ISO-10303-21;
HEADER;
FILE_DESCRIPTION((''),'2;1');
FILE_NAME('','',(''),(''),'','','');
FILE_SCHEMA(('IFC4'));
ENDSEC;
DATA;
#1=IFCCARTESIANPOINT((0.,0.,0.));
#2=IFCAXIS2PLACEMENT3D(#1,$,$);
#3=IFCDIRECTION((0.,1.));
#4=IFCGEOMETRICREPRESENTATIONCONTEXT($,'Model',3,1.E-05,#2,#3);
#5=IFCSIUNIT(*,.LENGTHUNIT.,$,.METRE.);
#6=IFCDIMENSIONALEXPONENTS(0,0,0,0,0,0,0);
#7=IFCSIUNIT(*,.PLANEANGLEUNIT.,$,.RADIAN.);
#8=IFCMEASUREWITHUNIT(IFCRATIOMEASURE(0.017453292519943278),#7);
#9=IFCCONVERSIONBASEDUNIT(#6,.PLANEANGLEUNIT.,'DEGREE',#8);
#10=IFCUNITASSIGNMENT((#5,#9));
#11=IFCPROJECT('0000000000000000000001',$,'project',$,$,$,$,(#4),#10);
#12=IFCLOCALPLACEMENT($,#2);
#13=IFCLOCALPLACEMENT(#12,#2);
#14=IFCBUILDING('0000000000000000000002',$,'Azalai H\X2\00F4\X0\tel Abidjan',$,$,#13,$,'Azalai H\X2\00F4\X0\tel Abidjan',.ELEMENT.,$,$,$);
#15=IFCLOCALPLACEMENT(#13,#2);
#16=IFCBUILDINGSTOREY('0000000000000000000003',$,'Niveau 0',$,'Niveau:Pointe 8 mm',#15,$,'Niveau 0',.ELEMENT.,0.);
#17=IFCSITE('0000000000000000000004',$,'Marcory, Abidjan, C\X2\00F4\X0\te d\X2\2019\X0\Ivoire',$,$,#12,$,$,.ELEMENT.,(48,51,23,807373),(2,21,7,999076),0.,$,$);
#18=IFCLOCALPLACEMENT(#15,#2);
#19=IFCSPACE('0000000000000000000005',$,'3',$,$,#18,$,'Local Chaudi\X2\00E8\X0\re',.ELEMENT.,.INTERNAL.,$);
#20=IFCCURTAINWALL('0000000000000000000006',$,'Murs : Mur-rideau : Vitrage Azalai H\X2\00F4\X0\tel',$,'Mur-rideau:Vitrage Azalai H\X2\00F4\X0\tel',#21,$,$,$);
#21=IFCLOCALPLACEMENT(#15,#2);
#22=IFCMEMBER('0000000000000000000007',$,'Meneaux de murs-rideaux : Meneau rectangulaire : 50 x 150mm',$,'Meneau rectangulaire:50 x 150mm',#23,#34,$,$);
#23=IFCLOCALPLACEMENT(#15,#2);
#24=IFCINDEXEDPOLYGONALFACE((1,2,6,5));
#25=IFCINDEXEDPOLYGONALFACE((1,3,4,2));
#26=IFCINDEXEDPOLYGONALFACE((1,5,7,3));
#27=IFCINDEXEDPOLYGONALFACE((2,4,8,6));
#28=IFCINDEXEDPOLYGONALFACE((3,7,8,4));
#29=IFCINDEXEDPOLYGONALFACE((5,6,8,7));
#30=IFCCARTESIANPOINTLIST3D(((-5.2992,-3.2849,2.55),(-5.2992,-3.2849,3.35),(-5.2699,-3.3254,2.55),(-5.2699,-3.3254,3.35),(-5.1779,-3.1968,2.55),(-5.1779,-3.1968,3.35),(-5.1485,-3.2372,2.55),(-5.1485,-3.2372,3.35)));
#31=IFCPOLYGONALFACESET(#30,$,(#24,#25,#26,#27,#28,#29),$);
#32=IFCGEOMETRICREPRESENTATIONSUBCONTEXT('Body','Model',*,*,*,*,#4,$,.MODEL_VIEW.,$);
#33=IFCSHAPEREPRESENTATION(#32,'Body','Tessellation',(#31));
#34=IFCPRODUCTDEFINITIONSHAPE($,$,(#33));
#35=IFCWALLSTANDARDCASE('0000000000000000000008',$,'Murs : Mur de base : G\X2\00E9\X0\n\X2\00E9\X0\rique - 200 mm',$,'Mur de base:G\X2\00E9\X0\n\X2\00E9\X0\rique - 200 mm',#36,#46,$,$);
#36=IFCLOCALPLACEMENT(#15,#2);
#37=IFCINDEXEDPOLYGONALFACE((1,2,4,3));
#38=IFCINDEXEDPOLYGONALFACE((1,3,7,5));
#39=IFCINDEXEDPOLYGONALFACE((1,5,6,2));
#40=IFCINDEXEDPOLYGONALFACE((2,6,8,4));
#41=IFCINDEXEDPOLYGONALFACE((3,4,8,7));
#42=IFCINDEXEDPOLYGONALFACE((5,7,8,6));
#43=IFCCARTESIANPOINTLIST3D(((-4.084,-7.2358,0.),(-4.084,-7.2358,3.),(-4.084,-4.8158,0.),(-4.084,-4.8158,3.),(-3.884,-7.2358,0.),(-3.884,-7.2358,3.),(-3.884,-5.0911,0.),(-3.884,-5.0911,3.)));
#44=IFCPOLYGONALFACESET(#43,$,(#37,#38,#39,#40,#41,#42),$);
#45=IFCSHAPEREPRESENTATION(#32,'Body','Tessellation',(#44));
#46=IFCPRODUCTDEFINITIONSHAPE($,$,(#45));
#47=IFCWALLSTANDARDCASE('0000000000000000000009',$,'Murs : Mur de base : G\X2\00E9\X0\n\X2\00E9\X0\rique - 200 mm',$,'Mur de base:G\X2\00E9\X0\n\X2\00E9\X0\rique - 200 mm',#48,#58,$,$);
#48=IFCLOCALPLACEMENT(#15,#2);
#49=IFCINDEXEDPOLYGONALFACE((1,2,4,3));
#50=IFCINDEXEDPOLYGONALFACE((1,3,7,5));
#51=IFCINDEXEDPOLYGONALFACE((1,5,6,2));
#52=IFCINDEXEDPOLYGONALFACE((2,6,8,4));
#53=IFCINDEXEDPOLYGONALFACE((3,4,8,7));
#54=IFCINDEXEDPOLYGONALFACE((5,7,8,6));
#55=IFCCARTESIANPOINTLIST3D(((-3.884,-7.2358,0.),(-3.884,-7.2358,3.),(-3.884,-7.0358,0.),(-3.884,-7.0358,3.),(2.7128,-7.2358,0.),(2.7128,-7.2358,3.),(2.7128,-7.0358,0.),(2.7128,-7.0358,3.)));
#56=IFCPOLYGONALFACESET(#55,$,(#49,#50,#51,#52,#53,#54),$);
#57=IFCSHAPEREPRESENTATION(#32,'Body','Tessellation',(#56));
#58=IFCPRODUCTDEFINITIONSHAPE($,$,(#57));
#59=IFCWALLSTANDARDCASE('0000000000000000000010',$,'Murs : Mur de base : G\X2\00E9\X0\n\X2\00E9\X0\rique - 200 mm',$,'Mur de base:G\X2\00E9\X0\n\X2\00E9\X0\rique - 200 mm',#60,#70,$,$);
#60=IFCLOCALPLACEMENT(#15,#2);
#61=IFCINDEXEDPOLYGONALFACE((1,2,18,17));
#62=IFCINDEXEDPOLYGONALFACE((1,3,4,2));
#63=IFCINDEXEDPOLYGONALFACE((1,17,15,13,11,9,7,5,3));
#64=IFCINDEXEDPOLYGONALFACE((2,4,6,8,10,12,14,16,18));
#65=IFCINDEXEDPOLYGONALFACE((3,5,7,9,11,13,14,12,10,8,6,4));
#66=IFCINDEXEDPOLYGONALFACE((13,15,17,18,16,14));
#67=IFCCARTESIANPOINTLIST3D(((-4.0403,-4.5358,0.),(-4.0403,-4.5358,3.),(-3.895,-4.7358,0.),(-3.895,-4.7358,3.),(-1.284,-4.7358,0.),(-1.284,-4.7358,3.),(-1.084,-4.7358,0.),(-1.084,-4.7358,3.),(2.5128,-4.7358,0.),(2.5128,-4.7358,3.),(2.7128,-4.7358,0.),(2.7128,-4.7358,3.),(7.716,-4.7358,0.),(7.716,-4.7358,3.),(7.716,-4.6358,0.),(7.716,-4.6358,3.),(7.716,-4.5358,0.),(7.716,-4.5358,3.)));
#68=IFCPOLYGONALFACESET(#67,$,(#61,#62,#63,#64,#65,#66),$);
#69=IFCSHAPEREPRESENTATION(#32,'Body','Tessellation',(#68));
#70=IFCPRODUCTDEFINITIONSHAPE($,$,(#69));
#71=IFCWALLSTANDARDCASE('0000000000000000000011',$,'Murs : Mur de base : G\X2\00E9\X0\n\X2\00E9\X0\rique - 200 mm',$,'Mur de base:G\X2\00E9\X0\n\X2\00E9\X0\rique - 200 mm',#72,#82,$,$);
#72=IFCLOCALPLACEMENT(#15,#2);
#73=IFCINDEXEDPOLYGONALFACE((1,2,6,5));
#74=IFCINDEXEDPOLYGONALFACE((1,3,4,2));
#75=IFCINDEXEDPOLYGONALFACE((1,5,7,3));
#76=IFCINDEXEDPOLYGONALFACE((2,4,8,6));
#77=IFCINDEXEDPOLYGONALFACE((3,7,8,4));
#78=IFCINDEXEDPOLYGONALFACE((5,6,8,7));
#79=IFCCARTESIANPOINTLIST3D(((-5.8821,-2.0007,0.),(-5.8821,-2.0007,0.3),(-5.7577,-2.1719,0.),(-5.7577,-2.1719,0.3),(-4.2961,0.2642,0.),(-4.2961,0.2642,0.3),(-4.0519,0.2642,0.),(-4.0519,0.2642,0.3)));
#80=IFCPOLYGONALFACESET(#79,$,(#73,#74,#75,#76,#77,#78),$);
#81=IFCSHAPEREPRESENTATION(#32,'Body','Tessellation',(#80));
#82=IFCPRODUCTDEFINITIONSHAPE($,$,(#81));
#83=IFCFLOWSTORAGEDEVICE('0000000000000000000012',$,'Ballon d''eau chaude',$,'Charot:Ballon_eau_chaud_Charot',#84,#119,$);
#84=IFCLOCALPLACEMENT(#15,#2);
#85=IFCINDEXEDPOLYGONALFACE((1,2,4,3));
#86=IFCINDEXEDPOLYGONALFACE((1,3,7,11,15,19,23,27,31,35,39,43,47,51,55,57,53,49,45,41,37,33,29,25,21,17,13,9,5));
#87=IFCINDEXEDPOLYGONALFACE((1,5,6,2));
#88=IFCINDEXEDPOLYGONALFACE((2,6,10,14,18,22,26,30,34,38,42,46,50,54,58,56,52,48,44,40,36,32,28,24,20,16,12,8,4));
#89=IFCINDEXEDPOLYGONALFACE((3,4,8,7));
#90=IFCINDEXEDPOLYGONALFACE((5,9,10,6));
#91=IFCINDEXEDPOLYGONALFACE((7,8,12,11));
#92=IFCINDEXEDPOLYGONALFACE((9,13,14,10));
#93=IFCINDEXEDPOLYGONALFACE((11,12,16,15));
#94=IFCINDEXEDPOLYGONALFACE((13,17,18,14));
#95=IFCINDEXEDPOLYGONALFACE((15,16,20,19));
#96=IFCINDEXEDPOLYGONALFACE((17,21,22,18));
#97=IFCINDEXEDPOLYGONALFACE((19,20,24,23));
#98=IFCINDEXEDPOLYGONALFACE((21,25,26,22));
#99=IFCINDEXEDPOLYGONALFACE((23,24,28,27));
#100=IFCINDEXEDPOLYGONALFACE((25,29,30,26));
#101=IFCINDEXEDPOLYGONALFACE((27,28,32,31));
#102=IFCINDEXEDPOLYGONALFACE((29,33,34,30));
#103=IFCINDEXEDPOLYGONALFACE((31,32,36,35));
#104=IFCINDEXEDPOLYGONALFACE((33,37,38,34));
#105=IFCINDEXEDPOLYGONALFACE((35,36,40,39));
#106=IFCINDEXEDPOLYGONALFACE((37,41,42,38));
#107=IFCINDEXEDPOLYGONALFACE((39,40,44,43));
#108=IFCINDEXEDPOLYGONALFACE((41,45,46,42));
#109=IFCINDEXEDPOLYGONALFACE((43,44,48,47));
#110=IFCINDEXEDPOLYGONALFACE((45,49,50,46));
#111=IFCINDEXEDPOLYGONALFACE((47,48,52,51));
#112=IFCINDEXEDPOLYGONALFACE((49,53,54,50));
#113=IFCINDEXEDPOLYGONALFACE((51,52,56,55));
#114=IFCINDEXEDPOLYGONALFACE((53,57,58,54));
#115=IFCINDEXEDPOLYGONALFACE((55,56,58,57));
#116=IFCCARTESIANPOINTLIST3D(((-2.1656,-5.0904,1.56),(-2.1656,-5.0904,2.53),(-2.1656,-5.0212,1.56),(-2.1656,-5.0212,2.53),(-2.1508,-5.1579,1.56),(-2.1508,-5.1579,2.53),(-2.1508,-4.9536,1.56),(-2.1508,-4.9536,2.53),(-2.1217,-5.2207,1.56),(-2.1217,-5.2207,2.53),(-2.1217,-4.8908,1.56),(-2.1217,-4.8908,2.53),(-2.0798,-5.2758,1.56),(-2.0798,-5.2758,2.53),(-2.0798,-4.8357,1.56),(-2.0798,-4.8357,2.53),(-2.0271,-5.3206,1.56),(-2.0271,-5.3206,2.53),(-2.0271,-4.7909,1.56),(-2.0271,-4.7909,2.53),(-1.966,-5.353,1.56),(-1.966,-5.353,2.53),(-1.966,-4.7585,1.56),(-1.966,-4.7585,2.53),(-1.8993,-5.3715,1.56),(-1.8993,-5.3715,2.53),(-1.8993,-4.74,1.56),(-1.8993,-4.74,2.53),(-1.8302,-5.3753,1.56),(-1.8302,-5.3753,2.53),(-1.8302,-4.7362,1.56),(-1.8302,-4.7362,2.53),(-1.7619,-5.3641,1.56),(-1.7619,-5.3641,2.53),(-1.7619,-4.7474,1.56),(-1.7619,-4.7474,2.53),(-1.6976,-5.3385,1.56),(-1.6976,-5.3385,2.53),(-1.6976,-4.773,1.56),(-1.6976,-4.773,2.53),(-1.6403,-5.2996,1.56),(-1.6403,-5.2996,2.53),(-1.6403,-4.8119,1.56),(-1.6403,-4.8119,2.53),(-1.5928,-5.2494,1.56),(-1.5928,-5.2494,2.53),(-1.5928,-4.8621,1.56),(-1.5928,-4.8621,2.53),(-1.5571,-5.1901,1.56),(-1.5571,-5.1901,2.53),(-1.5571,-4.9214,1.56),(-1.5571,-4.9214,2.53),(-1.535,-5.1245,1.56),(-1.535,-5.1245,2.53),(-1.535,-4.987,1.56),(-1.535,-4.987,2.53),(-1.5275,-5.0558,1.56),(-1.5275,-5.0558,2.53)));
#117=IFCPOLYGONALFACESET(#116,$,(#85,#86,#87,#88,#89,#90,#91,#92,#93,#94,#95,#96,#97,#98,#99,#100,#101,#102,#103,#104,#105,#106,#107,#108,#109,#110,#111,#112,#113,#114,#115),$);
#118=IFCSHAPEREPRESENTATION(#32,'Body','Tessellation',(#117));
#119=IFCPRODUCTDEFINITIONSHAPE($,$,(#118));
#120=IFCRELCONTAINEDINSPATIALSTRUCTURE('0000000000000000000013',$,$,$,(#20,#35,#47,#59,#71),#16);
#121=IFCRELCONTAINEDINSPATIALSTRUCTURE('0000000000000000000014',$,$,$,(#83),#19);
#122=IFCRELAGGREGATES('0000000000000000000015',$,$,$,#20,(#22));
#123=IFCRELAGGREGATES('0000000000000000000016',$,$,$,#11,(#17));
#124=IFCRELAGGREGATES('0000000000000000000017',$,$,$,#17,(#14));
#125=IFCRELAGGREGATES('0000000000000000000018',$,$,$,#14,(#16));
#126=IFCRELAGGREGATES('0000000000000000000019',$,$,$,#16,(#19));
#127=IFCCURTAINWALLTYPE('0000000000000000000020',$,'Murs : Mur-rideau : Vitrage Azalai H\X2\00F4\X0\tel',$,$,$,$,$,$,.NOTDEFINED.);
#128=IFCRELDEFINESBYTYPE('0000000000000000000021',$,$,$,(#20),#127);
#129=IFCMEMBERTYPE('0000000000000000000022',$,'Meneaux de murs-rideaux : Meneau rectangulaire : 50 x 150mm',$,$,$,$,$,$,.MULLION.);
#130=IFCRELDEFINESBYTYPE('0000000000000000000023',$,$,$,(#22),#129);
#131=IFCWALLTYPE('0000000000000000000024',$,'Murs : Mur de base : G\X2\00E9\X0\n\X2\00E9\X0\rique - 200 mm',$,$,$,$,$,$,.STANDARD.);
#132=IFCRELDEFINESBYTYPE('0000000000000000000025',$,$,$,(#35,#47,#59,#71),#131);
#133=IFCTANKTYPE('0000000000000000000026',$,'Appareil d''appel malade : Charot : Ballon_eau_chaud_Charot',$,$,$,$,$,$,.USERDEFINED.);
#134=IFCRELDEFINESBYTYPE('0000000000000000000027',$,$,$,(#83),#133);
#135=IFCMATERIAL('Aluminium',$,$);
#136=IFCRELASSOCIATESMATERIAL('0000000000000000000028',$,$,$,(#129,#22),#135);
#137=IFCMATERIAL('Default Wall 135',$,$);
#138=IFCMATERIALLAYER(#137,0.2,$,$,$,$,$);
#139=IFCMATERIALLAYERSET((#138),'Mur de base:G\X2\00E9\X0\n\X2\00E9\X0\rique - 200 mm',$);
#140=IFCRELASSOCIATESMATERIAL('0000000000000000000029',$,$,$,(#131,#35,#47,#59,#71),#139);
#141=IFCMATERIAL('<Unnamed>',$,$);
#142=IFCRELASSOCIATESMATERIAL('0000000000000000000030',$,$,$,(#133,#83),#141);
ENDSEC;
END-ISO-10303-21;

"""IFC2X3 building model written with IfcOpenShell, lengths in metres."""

from ifc_helpers import new_model, entity, si_unit, converted_unit, direction, frame, frame_2d, origin, origin_2d_with_axis, place, context, subcontext, project, spatial, polyline, rectangle, circle, outline, extrude, clip, halfspace, source, transform, mapped, material, layer, layer_set, layer_usage, type_object, type_shapes, element, aggregate, save


model = new_model("IFC2X3")

# Units and contexts
model_context = context("Model", 3, precision=1e-05, world=origin(), true_north=direction((0.0, 1.0)))
body_context = subcontext(model_context, "Body", "Model", "MODEL_VIEW")
ifc_project = project(units=[si_unit("LENGTHUNIT", "METRE"), converted_unit("PLANEANGLEUNIT", "DEGREE", entity("IfcRatioMeasure", 0.017453292519943278), si_unit("PLANEANGLEUNIT", "RADIAN"), dimensions=[0, 0, 0, 0, 0, 0, 0])], contexts=[model_context])

# Site, building, storey
site_placement = place(None, origin())
site = spatial("IfcSite", under=ifc_project, at=site_placement, Name="Marcory, Abidjan, Côte d’Ivoire", CompositionType="ELEMENT", RefLatitude=(48, 51, 23, 807373), RefLongitude=(2, 21, 7, 999076), RefElevation=0.0)
building_placement = place(site_placement, origin())
building = spatial("IfcBuilding", under=site, at=building_placement, Name="Azalai Hôtel Abidjan", LongName="Azalai Hôtel Abidjan", CompositionType="ELEMENT")
storey_placement = place(building_placement, origin())
storey = spatial("IfcBuildingStorey", under=building, at=storey_placement, Name="Niveau 0", ObjectType="Niveau:Pointe 8 mm", LongName="Niveau 0", CompositionType="ELEMENT", Elevation=0.0)

# Curtain wall, member
curtain_wall_type = type_object("IfcCurtainWallType", Name="Murs : Mur-rideau : Vitrage Azalai Hôtel", PredefinedType="NOTDEFINED")
ifc_material_1 = material(Name="Aluminium")
curtain_wall_1_placement = place(storey_placement, origin())
curtain_wall_1 = element("IfcCurtainWall", 1, at=curtain_wall_1_placement, inside=storey, type_object=curtain_wall_type, Name="Murs : Mur-rideau : Vitrage Azalai Hôtel", ObjectType="Mur-rideau:Vitrage Azalai Hôtel")
member_type_1 = type_object("IfcMemberType", Name="Meneaux de murs-rideaux : Meneau rectangulaire : 50 x 150mm", PredefinedType="MULLION", material=ifc_material_1)
shared_shape_1 = source(origin(), body_context, "Body", "SweptSolid", [
    extrude(rectangle(XDim=0.15, YDim=0.05, at=origin_2d_with_axis()), frame((-0.025, 0.0, -0.8), z_axis=(0.0, 0.0, 1.0), x_axis=(0.0, -1.0, 0.0)), (0.0, 0.0, 1.0), 0.8),
])
type_shapes(member_type_1, [shared_shape_1])
member_1_placement = place(curtain_wall_1_placement, frame((-5.2092, -3.2813, 2.55), z_axis=(0.0, 0.0, -1.0), x_axis=(0.587785, -0.809017, 0.0)))
member_1 = element("IfcMember", 2, at=member_1_placement, type_object=member_type_1, material=ifc_material_1, Name="Meneaux de murs-rideaux : Meneau rectangulaire : 50 x 150mm", ObjectType="Meneau rectangulaire:50 x 150mm", context=body_context, shape_type="MappedRepresentation", body=[
    mapped(shared_shape_1, transform((0.0, 0.0, 0.0), scale=1.0)),
])

aggregate(curtain_wall_1, [member_1])

# Walls
ifc_material_2 = material(Name="Default Wall 135")
ifc_layer = layer(ifc_material_2, 0.2)
ifc_layer_set = layer_set([ifc_layer], Name="Mur de base:Générique - 200 mm")
ifc_layer_usage = layer_usage(ifc_layer_set, "AXIS2", "NEGATIVE", 0.1)
wall_type = type_object("IfcWallType", Name="Murs : Mur de base : Générique - 200 mm", PredefinedType="STANDARD", material=ifc_layer_set)
wall_1_placement = place(storey_placement, frame((-3.984, -4.8158, 0.0), z_axis=(0.0, 0.0, 1.0), x_axis=(0.0, -1.0, 0.0)))
element("IfcWallStandardCase", 3, at=wall_1_placement, inside=storey, type_object=wall_type, material=ifc_layer_usage, Name="Murs : Mur de base : Générique - 200 mm", ObjectType="Mur de base:Générique - 200 mm", context=body_context, shape_type="Clipping", body=[
    clip(extrude(outline(polyline([(2.4199, -0.1), (2.4199, 0.1), (2.2199, 0.1), (0.2753, 0.1), (0.0, -0.1), (2.4199, -0.1)])), origin(), (0.0, 0.0, 1.0), 3.0), halfspace(origin(), True)),
])
wall_2_placement = place(storey_placement, frame((-3.884, -7.1358, 0.0)))
element("IfcWallStandardCase", 4, at=wall_2_placement, inside=storey, type_object=wall_type, material=ifc_layer_usage, Name="Murs : Mur de base : Générique - 200 mm", ObjectType="Mur de base:Générique - 200 mm", context=body_context, shape_type="Clipping", body=[
    clip(extrude(rectangle(XDim=6.5968, YDim=0.2, at=frame_2d((3.2984, 0.0), x_axis=(-1.0, 0.0))), origin(), (0.0, 0.0, 1.0), 3.0), halfspace(origin(), True)),
])
wall_3_placement = place(storey_placement, frame((-4.0403, -4.6358, 0.0)))
element("IfcWallStandardCase", 5, at=wall_3_placement, inside=storey, type_object=wall_type, material=ifc_layer_usage, Name="Murs : Mur de base : Générique - 200 mm", ObjectType="Mur de base:Générique - 200 mm", context=body_context, shape_type="SweptSolid", body=[
    extrude(outline(polyline([(11.7563, -0.1), (11.7563, 0.0), (11.7563, 0.1), (0.0, 0.1), (0.1453, -0.1), (2.7563, -0.1), (2.9563, -0.1), (6.5531, -0.1), (6.7531, -0.1), (11.7563, -0.1)])), origin(), (0.0, 0.0, 1.0), 3.0),
])
wall_4_placement = place(storey_placement, frame((-4.1339, 0.3216, 0.0), z_axis=(0.0, 0.0, 1.0), x_axis=(-0.573576, -0.819152, 0.0)))
element("IfcWallStandardCase", 6, at=wall_4_placement, inside=storey, type_object=wall_type, material=ifc_layer_usage, Name="Murs : Mur de base : Générique - 200 mm", ObjectType="Mur de base:Générique - 200 mm", context=body_context, shape_type="SweptSolid", body=[
    extrude(outline(polyline([(2.9051, -0.1), (2.9739, 0.1), (0.0, 0.1), (0.14, -0.1), (2.9051, -0.1)])), origin(), (0.0, 0.0, 1.0), 0.3),
])

# Shared definitions
space_placement = place(storey_placement, origin())
space = spatial("IfcSpace", under=storey, at=space_placement, Name="3", LongName="Local Chaudière", CompositionType="ELEMENT", InteriorOrExteriorSpace="INTERNAL")

# Flow storage device
ifc_material_3 = material(Name="<Unnamed>")
tank_type = type_object("IfcTankType", Name="Appareil d'appel malade : Charot : Ballon_eau_chaud_Charot", PredefinedType="USERDEFINED", material=ifc_material_3)
shared_shape_2 = source(origin(), body_context, "Body", "SweptSolid", [
    extrude(circle(Radius=0.32, at=frame_2d((0.0, 0.0), x_axis=(1.0, 0.0))), origin(), (0.0, 0.0, 1.0), 0.97),
])
type_shapes(tank_type, [shared_shape_2])
flow_storage_device_placement = place(space_placement, frame((-1.8475, -5.0558, 1.56)))
element("IfcFlowStorageDevice", 7, at=flow_storage_device_placement, inside=space, type_object=tank_type, material=ifc_material_3, Name="Ballon d'eau chaude", ObjectType="Charot:Ballon_eau_chaud_Charot", context=body_context, shape_type="MappedRepresentation", body=[
    mapped(shared_shape_2, transform((0.0, 0.0, 0.0), scale=1.0)),
])

save(model, "model.ifc")
